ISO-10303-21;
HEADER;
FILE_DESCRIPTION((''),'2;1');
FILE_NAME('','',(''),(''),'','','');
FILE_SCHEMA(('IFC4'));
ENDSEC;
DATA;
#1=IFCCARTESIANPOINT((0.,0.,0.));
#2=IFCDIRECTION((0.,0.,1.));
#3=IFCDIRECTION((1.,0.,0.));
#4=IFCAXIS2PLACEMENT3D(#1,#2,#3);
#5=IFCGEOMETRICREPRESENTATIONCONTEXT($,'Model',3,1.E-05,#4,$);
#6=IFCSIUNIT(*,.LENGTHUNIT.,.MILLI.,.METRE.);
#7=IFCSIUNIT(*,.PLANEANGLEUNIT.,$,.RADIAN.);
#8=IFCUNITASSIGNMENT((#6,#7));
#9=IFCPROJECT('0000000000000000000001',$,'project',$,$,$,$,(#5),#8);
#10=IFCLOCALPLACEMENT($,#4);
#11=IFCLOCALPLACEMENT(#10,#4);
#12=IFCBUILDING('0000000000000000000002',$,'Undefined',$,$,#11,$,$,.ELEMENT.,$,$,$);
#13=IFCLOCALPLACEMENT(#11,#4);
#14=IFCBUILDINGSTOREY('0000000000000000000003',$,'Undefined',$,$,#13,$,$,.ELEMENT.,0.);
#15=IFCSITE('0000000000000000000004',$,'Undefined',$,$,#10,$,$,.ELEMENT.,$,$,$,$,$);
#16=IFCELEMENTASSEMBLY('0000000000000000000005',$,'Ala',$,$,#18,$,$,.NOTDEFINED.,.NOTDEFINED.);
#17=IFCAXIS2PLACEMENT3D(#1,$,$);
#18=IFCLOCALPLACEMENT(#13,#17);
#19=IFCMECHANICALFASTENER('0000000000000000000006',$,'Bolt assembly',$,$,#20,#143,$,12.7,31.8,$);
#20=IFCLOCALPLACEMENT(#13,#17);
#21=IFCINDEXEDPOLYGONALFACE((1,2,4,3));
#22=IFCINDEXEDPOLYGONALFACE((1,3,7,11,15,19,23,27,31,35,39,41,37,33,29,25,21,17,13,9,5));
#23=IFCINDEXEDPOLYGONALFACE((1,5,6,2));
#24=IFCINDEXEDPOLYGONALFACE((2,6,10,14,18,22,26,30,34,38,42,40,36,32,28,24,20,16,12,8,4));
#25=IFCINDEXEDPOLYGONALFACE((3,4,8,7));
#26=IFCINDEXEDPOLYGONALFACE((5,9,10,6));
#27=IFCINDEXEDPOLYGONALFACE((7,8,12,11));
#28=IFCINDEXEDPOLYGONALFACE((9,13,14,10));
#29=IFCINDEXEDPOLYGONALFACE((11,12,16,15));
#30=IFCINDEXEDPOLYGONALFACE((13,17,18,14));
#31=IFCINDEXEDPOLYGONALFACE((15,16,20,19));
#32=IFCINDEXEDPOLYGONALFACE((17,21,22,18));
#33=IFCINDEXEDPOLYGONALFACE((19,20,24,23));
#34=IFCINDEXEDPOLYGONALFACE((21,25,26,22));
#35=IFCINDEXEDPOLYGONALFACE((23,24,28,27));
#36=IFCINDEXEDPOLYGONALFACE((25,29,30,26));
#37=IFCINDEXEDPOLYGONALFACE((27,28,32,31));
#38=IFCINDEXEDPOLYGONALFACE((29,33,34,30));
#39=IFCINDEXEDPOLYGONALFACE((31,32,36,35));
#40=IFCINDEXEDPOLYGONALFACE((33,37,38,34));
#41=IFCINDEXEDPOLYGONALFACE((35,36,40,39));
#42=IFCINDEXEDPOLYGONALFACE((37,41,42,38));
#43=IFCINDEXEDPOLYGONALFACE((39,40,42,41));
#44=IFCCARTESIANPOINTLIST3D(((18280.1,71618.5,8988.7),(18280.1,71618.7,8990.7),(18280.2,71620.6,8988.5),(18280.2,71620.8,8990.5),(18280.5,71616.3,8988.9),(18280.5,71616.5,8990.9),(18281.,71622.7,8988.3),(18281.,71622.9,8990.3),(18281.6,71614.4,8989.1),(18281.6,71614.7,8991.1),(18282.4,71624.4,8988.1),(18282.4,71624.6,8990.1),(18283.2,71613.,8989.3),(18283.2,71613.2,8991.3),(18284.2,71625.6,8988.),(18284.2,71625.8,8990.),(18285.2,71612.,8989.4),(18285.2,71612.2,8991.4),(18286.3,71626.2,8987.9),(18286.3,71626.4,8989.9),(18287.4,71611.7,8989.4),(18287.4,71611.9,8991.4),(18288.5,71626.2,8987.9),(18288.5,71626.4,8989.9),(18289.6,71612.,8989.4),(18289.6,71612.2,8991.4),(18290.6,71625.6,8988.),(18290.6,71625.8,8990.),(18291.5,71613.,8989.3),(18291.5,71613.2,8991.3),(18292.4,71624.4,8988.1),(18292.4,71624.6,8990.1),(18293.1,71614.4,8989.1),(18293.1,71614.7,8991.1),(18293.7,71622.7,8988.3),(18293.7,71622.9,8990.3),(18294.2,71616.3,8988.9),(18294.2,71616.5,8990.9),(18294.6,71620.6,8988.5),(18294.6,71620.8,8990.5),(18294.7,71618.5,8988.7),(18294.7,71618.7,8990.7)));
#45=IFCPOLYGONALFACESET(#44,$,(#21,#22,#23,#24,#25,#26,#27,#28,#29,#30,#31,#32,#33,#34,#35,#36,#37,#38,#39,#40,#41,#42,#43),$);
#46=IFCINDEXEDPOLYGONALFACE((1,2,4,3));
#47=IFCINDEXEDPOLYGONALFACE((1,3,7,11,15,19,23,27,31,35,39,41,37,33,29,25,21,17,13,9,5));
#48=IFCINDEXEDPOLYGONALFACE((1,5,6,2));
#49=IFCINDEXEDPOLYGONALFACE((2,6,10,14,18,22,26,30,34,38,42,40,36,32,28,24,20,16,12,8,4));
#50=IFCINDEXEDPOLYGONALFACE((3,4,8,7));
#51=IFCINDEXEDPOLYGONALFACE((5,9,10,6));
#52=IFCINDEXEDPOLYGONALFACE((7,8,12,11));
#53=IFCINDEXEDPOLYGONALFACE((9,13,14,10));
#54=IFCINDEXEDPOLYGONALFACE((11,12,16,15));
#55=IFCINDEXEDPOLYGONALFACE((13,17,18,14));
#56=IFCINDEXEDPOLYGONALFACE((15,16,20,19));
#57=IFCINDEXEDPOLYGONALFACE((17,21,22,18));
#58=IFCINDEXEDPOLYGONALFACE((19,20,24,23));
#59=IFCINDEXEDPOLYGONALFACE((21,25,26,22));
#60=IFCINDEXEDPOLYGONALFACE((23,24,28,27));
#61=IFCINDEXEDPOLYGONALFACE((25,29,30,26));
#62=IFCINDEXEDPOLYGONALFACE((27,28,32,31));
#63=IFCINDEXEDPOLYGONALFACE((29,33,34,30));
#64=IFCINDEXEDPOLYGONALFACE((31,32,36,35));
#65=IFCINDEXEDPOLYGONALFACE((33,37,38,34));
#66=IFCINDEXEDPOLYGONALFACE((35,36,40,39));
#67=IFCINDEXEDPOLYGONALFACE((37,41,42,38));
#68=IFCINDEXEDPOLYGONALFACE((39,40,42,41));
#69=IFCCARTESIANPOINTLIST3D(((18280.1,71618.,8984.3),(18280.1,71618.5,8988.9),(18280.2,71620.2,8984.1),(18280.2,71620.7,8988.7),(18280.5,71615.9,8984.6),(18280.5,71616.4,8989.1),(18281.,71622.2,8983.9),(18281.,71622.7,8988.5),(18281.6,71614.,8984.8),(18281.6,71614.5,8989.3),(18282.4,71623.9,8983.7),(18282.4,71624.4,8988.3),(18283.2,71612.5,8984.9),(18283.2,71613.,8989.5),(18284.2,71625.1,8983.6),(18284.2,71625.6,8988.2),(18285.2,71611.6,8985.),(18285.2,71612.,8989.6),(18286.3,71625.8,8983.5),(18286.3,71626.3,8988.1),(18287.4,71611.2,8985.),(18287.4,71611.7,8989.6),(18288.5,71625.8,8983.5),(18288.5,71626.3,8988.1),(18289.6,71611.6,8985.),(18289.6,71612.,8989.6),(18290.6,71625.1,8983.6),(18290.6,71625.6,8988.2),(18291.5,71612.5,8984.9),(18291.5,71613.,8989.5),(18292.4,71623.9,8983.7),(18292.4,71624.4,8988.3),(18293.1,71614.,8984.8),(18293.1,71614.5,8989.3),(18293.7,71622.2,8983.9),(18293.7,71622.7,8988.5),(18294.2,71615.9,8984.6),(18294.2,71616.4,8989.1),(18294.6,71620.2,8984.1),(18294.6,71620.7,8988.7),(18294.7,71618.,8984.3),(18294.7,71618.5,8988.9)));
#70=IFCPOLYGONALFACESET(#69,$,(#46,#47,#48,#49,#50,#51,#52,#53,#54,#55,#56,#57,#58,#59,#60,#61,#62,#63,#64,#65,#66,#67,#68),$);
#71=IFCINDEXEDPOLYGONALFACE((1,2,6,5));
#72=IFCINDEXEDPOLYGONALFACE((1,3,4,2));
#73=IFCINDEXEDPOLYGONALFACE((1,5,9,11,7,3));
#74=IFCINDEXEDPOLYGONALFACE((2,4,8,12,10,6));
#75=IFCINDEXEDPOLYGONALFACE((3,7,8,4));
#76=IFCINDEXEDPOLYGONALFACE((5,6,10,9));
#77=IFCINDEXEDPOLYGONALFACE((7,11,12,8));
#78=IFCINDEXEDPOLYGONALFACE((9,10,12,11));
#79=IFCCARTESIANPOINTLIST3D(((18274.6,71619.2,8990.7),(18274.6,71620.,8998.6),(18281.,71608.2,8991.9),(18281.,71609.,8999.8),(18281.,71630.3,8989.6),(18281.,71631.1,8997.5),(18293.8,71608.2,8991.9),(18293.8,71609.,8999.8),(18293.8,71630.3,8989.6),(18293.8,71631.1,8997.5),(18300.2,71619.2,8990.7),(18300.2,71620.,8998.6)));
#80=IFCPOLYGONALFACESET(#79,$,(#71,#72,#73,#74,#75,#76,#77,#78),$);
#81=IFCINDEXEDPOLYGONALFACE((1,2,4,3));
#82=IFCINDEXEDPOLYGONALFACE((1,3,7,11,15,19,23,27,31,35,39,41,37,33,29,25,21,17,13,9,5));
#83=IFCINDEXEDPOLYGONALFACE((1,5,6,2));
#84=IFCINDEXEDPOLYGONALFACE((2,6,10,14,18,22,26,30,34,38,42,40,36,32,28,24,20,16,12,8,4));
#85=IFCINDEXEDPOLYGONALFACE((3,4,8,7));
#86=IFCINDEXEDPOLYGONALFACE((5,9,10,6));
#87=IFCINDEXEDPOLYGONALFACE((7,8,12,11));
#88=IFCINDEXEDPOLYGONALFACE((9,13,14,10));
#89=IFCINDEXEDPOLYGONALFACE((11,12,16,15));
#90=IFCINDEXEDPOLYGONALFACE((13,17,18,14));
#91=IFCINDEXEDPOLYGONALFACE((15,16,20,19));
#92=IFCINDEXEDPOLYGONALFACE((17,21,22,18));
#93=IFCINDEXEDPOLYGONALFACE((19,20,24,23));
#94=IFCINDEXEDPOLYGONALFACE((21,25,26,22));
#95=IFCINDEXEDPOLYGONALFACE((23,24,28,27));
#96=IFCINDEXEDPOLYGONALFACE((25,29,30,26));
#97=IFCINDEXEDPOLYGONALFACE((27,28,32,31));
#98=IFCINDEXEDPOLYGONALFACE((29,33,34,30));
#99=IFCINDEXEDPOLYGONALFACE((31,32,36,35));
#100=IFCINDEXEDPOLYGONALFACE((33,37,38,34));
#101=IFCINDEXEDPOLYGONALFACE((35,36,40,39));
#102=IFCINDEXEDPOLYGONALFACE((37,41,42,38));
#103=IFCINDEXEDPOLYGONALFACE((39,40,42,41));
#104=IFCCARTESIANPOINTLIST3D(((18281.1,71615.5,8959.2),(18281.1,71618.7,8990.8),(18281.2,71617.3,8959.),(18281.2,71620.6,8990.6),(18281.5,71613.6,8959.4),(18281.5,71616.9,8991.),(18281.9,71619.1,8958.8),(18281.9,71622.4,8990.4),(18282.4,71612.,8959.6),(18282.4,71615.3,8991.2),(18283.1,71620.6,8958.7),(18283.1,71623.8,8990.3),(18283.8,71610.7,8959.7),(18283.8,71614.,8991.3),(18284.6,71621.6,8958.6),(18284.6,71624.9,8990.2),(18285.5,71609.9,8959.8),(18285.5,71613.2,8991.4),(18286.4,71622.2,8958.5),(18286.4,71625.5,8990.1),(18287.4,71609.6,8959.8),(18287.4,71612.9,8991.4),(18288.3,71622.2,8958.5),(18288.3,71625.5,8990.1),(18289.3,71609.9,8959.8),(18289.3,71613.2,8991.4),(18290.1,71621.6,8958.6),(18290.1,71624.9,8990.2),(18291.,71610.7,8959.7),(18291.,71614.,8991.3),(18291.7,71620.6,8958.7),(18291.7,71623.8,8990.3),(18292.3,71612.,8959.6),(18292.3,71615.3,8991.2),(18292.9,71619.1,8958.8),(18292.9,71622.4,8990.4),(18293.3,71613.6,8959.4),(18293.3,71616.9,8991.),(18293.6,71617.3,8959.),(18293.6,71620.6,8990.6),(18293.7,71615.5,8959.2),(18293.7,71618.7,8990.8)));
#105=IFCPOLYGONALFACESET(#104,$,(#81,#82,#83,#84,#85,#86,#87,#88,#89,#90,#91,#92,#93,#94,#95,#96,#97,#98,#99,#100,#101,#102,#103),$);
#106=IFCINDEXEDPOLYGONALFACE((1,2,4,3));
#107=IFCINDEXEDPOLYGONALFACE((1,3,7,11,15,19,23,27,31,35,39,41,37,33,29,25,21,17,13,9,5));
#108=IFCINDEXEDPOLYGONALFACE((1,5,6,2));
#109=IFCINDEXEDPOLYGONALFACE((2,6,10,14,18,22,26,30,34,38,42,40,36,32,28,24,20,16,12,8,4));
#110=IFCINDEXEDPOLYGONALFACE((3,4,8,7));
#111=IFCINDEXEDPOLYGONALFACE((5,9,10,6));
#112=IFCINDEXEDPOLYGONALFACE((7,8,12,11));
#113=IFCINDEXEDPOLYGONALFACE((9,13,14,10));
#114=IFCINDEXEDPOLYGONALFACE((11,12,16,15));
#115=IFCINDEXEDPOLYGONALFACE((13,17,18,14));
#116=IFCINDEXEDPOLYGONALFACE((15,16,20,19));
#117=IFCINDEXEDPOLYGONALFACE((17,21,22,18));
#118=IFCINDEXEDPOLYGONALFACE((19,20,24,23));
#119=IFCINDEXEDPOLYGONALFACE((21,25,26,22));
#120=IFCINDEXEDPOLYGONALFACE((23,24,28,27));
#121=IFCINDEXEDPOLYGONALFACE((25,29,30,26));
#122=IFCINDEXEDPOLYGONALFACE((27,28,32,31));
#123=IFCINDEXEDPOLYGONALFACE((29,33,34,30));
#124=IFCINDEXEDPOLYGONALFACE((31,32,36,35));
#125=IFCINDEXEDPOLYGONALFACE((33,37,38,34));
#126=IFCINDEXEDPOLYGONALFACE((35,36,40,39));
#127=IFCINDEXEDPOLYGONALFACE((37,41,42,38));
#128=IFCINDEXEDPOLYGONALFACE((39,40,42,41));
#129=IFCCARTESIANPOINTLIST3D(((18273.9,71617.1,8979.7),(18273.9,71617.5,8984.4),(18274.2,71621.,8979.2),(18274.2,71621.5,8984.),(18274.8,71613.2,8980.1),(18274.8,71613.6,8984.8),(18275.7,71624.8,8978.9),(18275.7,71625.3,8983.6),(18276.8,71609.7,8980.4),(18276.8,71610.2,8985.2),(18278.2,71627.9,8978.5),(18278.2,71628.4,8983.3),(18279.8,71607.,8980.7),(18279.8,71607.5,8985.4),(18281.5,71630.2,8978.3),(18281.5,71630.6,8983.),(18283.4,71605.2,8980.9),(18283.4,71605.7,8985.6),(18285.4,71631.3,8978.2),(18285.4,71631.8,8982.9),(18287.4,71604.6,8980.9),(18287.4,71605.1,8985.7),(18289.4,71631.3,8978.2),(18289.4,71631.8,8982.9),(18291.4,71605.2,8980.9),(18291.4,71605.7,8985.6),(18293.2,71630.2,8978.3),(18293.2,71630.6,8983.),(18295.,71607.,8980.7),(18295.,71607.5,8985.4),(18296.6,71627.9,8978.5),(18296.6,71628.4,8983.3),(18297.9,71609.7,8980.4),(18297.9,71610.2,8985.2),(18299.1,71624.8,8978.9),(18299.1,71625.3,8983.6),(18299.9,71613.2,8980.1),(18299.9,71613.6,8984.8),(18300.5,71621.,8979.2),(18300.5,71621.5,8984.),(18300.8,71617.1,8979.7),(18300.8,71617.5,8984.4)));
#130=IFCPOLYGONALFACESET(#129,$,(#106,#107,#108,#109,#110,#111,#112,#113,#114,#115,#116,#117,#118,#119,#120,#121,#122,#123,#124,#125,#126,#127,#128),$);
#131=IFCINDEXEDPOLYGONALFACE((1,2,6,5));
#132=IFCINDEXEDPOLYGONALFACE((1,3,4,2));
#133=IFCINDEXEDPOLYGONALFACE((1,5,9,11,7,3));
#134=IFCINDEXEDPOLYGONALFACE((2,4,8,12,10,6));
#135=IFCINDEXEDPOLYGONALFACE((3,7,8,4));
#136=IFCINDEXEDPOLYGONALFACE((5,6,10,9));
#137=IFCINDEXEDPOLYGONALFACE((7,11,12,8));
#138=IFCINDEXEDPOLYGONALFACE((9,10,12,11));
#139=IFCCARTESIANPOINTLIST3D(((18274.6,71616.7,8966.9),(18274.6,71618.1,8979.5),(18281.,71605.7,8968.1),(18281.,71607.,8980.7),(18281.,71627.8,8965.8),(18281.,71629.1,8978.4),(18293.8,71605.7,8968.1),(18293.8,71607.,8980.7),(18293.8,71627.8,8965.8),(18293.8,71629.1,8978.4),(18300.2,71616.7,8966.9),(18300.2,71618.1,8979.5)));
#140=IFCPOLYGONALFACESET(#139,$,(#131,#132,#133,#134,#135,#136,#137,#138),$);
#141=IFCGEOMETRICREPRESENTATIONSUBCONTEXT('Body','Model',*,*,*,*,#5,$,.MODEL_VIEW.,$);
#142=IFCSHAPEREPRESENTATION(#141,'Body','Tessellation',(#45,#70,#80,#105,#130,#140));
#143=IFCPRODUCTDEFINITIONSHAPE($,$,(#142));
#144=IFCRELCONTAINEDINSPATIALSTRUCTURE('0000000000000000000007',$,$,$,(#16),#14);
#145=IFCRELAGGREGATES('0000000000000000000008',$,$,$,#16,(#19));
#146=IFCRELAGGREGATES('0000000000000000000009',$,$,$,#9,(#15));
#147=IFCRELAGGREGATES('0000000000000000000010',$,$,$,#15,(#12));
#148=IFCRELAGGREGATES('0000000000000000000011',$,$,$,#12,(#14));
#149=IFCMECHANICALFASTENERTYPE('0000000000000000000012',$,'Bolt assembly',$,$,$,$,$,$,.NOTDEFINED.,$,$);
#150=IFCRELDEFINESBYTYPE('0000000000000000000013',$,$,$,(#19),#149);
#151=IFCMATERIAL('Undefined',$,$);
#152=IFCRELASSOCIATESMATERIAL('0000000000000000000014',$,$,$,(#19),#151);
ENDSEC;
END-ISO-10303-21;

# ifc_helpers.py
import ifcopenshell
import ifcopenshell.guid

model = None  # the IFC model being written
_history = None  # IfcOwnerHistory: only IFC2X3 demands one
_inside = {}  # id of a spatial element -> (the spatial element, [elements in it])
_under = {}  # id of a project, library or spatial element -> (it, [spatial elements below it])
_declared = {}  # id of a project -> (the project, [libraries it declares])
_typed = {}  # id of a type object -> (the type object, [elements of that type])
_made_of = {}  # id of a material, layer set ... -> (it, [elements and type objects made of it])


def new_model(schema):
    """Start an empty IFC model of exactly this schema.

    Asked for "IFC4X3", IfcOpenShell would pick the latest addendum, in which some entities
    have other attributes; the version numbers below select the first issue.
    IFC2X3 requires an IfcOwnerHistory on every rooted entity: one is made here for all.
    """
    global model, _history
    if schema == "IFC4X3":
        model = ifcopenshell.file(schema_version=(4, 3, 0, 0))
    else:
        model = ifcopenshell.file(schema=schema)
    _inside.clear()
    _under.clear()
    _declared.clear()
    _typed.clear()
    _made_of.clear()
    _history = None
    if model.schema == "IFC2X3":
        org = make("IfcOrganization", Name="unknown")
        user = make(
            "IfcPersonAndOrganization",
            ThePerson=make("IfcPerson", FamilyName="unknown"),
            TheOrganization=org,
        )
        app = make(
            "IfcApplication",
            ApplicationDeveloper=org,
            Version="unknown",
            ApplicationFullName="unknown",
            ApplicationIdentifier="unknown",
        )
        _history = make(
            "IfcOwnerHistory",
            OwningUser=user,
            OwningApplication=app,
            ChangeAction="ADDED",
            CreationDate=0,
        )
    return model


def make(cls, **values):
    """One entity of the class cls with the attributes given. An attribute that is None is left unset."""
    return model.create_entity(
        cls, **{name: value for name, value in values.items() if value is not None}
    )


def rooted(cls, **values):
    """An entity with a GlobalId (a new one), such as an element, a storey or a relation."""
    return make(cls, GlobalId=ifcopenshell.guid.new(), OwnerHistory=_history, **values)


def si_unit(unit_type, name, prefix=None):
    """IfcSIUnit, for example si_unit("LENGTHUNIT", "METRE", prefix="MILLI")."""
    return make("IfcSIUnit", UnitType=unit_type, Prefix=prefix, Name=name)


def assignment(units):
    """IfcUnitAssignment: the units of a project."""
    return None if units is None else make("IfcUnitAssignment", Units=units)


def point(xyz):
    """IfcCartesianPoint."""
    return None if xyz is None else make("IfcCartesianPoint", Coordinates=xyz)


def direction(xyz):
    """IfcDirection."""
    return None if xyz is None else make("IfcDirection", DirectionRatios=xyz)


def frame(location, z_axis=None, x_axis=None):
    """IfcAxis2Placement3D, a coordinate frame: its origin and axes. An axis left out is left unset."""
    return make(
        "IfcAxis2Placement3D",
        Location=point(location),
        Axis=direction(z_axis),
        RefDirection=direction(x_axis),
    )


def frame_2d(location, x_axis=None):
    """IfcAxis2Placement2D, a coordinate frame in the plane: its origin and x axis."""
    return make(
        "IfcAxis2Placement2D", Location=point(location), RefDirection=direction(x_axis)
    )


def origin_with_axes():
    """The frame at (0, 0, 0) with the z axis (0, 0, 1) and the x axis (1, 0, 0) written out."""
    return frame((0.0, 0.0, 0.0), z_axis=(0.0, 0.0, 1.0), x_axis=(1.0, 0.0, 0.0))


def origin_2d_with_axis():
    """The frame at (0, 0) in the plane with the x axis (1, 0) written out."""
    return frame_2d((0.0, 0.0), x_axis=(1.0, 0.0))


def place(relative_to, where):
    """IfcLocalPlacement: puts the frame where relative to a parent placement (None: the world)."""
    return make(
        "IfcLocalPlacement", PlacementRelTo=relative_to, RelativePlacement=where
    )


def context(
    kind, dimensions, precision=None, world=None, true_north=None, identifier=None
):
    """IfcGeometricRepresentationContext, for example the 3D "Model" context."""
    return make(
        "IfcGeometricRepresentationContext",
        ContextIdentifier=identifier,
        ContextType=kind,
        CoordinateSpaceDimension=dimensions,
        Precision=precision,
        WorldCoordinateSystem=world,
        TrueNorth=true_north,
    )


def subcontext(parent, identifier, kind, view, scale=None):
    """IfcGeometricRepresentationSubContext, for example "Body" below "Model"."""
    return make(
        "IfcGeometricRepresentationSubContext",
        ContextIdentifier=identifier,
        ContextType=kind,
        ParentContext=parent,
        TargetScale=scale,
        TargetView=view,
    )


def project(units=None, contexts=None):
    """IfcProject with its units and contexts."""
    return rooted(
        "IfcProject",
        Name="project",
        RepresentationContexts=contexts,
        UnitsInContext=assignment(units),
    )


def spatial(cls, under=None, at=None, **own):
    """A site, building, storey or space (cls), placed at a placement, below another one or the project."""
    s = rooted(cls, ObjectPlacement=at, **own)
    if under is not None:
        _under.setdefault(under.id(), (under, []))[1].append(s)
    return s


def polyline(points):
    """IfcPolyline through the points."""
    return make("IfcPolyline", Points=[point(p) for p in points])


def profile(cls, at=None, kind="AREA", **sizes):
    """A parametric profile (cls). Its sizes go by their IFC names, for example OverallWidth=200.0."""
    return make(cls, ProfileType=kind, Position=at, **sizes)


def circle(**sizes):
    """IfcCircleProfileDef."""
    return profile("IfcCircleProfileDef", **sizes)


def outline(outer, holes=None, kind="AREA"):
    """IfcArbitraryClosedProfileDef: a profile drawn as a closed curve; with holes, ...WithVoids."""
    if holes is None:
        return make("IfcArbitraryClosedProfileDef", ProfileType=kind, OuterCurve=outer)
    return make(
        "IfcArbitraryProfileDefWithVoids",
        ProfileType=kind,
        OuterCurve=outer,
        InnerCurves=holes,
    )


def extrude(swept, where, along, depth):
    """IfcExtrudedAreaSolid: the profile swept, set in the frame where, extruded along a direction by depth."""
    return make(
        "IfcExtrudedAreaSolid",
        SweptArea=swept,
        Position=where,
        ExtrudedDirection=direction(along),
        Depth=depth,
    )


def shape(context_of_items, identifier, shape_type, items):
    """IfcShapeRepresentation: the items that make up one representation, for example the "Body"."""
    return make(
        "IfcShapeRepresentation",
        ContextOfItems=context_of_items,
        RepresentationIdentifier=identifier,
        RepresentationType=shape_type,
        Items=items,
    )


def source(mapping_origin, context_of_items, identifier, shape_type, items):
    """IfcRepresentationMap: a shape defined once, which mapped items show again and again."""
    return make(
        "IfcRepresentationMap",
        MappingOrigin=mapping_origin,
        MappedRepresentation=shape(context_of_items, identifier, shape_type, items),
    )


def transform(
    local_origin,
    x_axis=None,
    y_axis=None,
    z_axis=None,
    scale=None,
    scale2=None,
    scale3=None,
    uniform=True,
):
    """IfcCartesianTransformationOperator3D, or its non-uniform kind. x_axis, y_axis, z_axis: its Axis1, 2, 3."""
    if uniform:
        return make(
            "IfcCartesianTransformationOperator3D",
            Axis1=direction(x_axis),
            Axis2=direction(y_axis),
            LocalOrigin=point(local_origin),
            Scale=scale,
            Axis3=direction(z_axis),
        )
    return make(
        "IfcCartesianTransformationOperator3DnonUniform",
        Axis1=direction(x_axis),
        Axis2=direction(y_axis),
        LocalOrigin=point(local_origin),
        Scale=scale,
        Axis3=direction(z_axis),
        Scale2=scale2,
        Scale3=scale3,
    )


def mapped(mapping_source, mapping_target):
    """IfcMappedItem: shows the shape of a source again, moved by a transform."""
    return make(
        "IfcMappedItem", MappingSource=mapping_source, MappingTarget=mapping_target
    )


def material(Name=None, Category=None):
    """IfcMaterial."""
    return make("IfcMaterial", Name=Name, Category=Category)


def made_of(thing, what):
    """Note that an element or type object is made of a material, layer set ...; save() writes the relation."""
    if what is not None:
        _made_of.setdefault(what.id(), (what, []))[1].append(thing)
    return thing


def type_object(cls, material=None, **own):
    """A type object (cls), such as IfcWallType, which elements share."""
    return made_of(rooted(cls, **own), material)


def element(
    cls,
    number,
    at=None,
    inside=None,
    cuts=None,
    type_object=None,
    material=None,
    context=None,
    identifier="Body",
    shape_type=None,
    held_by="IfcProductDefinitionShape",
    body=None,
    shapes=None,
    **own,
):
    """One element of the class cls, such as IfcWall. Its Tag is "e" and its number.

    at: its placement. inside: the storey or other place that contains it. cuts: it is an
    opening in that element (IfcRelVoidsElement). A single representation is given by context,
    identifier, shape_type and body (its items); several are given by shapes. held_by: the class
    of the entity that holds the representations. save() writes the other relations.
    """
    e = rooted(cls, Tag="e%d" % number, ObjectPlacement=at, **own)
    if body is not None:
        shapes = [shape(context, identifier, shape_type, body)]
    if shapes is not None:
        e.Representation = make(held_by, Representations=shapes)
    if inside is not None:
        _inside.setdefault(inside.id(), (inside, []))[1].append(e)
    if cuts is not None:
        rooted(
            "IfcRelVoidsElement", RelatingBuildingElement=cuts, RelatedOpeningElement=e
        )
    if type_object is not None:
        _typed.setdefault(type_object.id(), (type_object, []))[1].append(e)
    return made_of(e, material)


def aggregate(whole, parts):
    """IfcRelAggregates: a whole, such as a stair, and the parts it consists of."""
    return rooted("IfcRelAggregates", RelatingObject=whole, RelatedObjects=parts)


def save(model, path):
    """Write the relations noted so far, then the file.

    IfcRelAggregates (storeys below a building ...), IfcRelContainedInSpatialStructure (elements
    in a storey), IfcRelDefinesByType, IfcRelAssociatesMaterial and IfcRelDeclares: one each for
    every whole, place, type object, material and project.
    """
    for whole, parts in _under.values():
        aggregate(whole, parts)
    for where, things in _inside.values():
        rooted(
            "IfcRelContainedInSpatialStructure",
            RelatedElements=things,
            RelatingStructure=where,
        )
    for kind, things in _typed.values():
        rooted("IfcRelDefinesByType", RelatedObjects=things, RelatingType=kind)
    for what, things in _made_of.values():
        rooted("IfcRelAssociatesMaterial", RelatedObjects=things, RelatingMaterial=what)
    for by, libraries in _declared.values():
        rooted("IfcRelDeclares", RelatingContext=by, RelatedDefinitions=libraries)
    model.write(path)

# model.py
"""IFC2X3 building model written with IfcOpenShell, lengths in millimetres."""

from ifc_helpers import new_model, si_unit, frame, origin_with_axes, origin_2d_with_axis, place, context, subcontext, project, spatial, polyline, circle, outline, extrude, source, transform, mapped, material, type_object, element, aggregate, save


model = new_model("IFC2X3")

# Units and contexts
model_context = context("Model", 3, precision=1e-05, world=origin_with_axes())
body_context = subcontext(model_context, "Body", "Model", "MODEL_VIEW")
ifc_project = project(units=[si_unit("LENGTHUNIT", "METRE", prefix="MILLI"), si_unit("PLANEANGLEUNIT", "RADIAN")], contexts=[model_context])

# Site, building, storey
site_placement = place(None, origin_with_axes())
site = spatial("IfcSite", under=ifc_project, at=site_placement, Name="Undefined", CompositionType="ELEMENT")
building_placement = place(site_placement, origin_with_axes())
building = spatial("IfcBuilding", under=site, at=building_placement, Name="Undefined", CompositionType="ELEMENT")
storey_placement = place(building_placement, origin_with_axes())
storey = spatial("IfcBuildingStorey", under=building, at=storey_placement, Name="Undefined", CompositionType="ELEMENT", Elevation=0.0)

# Element assembly
assembly_1_placement = place(storey_placement, origin_with_axes())
assembly_1 = element("IfcElementAssembly", 1, at=assembly_1_placement, inside=storey, Name="Ala", AssemblyPlace="NOTDEFINED", PredefinedType="NOTDEFINED")

# Shared definitions
ifc_material_1 = material(Name="Undefined")
mechanical_fastener_type = type_object("IfcMechanicalFastenerType", Name="Bolt assembly")

# Mechanical fastener
shared_shape_1 = source(origin_with_axes(), body_context, "Body", "SweptSolid", [
    extrude(circle(Radius=7.3, at=origin_2d_with_axis()), frame((0.0, -1.9, 0.0), z_axis=(0.0, 1.0, 0.0), x_axis=(1.0, 0.0, 0.0)), (0.0, 0.0, 1.0), 2.0),
    extrude(circle(Radius=7.3, at=origin_2d_with_axis()), frame((0.0, -0.1, 0.0), z_axis=(0.0, 1.0, 0.0), x_axis=(1.0, 0.0, 0.0)), (0.0, 0.0, 1.0), 4.6),
    extrude(outline(polyline([(11.1, -6.4), (11.1, 6.4), (0.0, 12.8), (-11.1, 6.4), (-11.1, -6.4), (0.0, -12.8), (11.1, -6.4)])), frame((0.0, -9.9, 0.0), z_axis=(0.0, 1.0, 0.0), x_axis=(1.0, 0.0, 0.0)), (0.0, 0.0, 1.0), 7.9),
    extrude(circle(Radius=6.3, at=origin_2d_with_axis()), frame((0.0, -2.0, 0.0), z_axis=(0.0, 1.0, 0.0), x_axis=(1.0, 0.0, 0.0)), (0.0, 0.0, 1.0), 31.8),
    extrude(circle(Radius=13.5, at=origin_2d_with_axis()), frame((0.0, 4.5, 0.0), z_axis=(0.0, 1.0, 0.0), x_axis=(1.0, 0.0, 0.0)), (0.0, 0.0, 1.0), 4.8),
    extrude(outline(polyline([(11.1, -6.4), (11.1, 6.4), (0.0, 12.8), (-11.1, 6.4), (-11.1, -6.4), (0.0, -12.8), (11.1, -6.4)])), frame((0.0, 9.3, 0.0), z_axis=(0.0, 1.0, 0.0), x_axis=(1.0, 0.0, 0.0)), (0.0, 0.0, 1.0), 12.7),
])
mechanical_fastener_1_placement = place(assembly_1_placement, frame((18287.4, 71619.0, 8988.8), z_axis=(1.0, 0.0, 0.0), x_axis=(0.0, -0.994665, 0.103162)))
mechanical_fastener_1 = element("IfcMechanicalFastener", 2, at=mechanical_fastener_1_placement, type_object=mechanical_fastener_type, material=ifc_material_1, Name="Bolt assembly", NominalDiameter=12.7, NominalLength=31.8, context=body_context, shape_type="MappedRepresentation", body=[
    mapped(shared_shape_1, transform((0.0, 0.0, 0.0))),
])

aggregate(assembly_1, [mechanical_fastener_1])

save(model, "model.ifc")
